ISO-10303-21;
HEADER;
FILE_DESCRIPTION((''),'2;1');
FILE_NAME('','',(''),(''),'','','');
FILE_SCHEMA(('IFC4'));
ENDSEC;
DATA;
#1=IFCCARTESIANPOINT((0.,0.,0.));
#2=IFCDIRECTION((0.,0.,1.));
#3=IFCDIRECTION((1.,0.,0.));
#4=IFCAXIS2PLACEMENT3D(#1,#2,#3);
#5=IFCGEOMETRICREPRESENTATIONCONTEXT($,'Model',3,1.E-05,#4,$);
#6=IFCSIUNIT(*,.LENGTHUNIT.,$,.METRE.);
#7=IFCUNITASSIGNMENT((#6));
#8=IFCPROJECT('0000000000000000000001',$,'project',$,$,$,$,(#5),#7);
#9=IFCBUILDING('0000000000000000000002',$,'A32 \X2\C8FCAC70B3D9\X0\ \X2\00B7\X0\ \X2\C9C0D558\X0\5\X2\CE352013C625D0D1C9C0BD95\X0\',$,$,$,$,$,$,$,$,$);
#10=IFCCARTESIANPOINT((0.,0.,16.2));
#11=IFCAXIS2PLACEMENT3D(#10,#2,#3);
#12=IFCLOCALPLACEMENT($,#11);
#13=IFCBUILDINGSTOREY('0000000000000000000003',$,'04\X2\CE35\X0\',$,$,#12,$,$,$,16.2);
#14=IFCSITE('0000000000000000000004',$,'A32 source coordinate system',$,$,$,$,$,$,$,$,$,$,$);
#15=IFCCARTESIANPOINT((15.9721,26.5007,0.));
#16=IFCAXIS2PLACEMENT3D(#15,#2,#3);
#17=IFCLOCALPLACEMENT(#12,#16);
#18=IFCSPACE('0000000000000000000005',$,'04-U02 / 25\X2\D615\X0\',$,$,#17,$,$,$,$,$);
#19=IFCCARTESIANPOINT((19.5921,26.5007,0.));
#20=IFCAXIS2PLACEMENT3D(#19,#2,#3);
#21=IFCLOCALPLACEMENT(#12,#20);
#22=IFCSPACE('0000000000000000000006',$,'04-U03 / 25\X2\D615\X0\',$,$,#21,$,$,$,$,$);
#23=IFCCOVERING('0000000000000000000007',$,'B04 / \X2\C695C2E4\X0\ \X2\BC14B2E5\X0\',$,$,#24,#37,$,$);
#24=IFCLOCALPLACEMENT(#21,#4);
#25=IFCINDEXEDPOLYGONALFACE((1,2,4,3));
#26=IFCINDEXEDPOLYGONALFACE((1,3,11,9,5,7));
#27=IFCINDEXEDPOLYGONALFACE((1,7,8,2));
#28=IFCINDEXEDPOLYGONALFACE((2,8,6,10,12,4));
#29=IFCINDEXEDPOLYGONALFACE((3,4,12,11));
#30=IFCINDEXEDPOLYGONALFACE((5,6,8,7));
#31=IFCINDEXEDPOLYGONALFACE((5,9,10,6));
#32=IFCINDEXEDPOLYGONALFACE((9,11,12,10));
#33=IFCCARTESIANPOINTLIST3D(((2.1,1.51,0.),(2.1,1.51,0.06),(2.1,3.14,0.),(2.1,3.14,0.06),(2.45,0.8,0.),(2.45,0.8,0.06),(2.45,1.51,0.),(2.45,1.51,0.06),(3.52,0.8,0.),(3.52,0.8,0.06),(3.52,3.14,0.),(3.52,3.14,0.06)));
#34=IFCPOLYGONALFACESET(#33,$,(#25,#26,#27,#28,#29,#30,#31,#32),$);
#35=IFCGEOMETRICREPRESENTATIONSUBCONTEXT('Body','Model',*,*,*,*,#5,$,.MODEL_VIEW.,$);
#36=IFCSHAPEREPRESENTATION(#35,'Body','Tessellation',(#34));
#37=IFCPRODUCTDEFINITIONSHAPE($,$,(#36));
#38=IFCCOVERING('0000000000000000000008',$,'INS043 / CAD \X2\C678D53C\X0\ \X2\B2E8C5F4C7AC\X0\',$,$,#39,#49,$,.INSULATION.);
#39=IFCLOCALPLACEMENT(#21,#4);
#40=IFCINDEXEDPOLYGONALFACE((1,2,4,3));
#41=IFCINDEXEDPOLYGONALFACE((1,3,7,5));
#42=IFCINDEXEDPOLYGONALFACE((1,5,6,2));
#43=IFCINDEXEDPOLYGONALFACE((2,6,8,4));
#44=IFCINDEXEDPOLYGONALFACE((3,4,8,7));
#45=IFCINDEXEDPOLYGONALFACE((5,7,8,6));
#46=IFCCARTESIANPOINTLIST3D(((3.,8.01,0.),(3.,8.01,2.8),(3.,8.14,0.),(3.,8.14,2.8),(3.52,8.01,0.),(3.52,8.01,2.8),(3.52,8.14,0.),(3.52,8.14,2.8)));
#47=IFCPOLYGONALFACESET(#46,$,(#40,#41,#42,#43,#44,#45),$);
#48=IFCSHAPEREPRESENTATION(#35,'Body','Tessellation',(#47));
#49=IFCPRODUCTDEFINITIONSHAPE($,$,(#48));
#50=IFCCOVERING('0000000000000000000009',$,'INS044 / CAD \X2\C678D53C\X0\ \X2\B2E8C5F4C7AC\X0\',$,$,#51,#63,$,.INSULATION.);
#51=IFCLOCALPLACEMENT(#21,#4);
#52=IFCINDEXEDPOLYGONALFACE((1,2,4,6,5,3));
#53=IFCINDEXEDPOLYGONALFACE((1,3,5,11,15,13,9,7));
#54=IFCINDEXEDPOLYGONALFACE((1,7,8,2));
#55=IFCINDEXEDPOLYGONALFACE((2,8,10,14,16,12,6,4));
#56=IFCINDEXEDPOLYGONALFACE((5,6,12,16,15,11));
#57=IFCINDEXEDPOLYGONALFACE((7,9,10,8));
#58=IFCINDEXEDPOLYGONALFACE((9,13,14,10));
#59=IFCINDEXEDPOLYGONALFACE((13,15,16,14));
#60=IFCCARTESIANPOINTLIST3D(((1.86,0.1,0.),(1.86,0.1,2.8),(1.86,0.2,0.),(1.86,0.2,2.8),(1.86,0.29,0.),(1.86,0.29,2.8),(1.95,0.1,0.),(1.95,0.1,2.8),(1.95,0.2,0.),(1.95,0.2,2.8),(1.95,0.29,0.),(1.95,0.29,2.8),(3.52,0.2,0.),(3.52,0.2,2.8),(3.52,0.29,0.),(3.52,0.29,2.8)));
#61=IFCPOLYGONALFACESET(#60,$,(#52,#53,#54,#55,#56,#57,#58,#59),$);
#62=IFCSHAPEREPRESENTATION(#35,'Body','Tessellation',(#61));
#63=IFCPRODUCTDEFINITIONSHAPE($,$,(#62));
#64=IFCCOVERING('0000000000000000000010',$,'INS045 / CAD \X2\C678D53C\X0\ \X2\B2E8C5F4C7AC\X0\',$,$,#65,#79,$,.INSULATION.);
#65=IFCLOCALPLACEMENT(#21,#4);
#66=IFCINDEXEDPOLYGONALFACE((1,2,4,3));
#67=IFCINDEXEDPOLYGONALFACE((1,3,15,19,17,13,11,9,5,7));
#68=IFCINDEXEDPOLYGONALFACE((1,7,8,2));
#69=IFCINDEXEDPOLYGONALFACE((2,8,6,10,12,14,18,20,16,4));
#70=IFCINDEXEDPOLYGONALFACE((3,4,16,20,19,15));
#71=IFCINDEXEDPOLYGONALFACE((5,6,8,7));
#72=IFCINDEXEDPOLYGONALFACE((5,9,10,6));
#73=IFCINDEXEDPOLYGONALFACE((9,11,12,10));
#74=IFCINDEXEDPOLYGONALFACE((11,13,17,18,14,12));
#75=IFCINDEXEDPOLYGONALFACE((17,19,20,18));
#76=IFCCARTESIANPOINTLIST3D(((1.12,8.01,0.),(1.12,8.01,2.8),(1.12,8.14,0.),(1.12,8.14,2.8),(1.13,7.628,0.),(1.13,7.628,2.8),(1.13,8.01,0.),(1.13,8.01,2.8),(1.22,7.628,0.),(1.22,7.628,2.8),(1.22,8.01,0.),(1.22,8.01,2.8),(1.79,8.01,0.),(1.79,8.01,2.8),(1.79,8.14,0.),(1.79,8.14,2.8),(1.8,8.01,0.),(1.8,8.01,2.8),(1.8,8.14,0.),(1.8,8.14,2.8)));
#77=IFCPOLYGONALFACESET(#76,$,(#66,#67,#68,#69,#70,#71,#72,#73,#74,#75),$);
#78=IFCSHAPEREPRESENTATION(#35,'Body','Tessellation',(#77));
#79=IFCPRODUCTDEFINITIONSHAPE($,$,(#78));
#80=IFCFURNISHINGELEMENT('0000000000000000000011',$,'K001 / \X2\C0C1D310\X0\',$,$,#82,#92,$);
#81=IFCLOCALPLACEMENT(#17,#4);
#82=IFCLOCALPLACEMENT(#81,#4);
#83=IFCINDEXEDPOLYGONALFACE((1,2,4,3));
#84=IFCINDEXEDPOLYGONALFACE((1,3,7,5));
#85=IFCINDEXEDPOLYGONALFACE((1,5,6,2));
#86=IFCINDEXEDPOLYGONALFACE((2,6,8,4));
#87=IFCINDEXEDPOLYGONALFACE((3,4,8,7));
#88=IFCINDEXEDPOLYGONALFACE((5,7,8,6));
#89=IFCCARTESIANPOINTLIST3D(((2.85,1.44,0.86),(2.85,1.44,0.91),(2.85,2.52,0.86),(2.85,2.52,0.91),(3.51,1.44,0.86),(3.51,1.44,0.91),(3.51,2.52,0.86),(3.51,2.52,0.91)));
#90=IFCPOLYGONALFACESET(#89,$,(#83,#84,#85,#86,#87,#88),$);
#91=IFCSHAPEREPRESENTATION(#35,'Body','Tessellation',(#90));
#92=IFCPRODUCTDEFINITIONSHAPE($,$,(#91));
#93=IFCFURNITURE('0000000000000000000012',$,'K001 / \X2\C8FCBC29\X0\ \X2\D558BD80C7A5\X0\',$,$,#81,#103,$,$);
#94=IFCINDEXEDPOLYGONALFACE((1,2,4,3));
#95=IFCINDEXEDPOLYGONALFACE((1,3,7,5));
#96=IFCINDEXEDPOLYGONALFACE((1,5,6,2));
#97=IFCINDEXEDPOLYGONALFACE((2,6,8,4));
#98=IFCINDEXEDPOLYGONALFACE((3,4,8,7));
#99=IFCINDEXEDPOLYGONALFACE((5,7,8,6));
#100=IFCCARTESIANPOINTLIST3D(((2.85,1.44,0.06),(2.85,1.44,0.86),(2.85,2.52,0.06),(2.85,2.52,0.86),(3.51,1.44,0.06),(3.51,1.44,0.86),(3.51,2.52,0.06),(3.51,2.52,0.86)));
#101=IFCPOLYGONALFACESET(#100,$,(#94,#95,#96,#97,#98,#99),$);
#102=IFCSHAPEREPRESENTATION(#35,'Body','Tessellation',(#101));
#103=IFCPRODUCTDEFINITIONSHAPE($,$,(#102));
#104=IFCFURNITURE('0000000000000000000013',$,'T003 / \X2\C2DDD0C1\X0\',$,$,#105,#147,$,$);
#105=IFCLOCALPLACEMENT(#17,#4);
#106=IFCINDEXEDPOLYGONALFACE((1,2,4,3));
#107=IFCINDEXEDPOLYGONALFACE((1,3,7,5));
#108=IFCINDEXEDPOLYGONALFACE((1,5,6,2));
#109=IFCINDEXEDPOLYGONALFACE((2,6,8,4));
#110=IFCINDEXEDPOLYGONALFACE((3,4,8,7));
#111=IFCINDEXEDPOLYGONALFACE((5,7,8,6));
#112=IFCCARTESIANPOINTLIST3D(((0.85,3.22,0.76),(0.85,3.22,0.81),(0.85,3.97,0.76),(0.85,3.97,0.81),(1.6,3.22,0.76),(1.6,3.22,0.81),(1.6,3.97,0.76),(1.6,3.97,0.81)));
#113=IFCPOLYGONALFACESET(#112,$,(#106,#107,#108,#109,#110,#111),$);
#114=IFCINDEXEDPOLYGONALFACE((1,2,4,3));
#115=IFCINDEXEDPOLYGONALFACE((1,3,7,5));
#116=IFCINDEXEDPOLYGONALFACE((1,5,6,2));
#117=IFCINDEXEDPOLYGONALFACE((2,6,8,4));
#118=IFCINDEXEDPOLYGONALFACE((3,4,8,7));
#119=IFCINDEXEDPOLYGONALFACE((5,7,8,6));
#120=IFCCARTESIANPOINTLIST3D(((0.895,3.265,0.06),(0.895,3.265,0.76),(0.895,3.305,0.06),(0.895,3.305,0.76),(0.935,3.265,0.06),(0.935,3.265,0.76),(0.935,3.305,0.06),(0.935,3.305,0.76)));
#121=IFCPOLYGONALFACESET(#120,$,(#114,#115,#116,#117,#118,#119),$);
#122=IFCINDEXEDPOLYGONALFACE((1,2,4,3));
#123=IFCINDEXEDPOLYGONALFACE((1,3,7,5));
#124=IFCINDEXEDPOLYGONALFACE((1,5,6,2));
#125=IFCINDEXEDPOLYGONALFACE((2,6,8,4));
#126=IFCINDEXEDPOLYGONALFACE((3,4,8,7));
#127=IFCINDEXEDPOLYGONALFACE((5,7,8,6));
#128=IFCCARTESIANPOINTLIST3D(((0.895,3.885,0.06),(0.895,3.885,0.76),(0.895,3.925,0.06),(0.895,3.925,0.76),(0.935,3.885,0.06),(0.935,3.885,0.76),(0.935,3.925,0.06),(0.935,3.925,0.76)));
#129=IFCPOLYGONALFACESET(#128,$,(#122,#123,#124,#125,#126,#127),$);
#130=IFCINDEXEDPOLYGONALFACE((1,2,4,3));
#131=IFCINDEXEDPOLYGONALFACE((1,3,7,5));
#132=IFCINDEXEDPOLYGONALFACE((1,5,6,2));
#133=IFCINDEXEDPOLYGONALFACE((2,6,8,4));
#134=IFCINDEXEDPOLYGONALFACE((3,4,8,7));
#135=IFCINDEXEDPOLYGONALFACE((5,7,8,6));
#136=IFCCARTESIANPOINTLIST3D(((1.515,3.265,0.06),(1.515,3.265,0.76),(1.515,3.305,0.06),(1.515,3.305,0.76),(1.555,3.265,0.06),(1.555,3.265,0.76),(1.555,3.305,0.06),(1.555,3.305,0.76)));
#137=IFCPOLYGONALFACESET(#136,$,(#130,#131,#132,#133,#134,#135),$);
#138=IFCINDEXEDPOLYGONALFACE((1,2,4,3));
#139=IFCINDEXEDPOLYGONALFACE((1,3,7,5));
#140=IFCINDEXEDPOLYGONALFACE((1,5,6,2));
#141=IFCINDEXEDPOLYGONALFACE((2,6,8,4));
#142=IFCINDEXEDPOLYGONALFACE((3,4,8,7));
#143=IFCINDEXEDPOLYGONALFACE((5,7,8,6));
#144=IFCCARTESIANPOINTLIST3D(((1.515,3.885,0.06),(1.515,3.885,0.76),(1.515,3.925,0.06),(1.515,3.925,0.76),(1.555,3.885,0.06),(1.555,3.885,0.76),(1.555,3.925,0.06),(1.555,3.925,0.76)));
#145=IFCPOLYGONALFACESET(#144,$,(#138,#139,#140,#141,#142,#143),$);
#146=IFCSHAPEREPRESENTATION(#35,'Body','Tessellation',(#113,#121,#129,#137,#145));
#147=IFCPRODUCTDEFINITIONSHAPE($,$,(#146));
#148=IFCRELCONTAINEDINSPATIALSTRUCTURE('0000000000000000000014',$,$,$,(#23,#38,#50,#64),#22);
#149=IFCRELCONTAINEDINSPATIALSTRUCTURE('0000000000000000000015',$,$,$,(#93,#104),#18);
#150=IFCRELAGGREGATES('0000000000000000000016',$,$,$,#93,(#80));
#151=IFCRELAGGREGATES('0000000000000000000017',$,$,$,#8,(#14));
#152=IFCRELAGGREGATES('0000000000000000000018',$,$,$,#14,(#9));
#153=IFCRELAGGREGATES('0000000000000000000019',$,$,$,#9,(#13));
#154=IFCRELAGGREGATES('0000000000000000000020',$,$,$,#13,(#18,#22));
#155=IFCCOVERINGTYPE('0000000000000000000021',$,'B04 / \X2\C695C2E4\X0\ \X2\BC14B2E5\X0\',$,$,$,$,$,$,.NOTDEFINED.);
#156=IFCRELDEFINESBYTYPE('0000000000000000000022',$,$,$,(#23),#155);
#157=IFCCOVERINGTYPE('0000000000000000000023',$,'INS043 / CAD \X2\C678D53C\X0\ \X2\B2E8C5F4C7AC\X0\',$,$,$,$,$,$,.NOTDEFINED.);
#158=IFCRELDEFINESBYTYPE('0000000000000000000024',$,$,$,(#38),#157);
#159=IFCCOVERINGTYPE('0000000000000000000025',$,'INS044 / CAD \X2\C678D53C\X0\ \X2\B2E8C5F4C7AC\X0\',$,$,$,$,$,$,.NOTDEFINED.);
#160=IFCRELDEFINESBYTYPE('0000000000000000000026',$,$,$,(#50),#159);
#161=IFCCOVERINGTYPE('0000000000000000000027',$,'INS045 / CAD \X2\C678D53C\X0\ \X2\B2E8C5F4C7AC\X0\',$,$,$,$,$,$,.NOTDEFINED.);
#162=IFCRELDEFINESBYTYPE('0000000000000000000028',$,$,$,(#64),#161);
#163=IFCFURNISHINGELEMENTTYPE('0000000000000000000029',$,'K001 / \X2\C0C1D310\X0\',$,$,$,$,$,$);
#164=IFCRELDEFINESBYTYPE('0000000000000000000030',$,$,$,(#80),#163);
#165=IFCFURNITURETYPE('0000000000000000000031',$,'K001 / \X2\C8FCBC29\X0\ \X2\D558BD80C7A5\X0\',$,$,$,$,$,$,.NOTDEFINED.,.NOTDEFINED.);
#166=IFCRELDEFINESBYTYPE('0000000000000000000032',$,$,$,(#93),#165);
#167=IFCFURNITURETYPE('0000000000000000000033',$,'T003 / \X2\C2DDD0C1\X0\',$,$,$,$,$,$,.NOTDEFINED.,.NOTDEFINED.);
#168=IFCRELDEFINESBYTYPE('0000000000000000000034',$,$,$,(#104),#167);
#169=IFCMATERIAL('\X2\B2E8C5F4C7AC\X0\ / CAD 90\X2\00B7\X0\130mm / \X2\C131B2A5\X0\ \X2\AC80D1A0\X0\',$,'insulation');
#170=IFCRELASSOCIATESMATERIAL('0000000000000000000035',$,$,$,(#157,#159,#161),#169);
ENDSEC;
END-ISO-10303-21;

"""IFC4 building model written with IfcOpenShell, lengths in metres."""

from ifc_helpers import new_model, si_unit, frame, origin, origin_with_axes, place, context, subcontext, project, spatial, polyline, outline, extrude, source, transform, mapped, material, type_object, type_shapes, element, aggregate, save


model = new_model("IFC4")

# Units and contexts
model_context = context("Model", 3, precision=1e-05, world=origin_with_axes())
body_context = subcontext(model_context, "Body", "Model", "MODEL_VIEW")
ifc_project = project(units=[si_unit("LENGTHUNIT", "METRE")], contexts=[model_context])

# Site, building, storey, space
site = spatial("IfcSite", under=ifc_project, Name="A32 source coordinate system")
building = spatial("IfcBuilding", under=site, Name="A32 주거동 · 지하5층–옥탑지붕")
storey_placement = place(None, frame((0.0, 0.0, 16.2), z_axis=(0.0, 0.0, 1.0), x_axis=(1.0, 0.0, 0.0)))
storey = spatial("IfcBuildingStorey", under=building, at=storey_placement, Name="04층", Elevation=16.2)
space_1_placement = place(storey_placement, frame((15.9721, 26.5007, 0.0), z_axis=(0.0, 0.0, 1.0), x_axis=(1.0, 0.0, 0.0)))
space_1 = spatial("IfcSpace", under=storey, at=space_1_placement, Name="04-U02 / 25형")

# Shared definitions
space_2_placement = place(storey_placement, frame((19.5921, 26.5007, 0.0), z_axis=(0.0, 0.0, 1.0), x_axis=(1.0, 0.0, 0.0)))
space_2 = spatial("IfcSpace", under=storey, at=space_2_placement, Name="04-U03 / 25형")

# Coverings
covering_type_1 = type_object("IfcCoveringType", Name="B04 / 욕실 바닥", PredefinedType="NOTDEFINED")
shared_shape_1 = source(origin(), body_context, "Body", "SweptSolid", [
    extrude(outline(polyline([(2.1, 1.51), (2.1, 3.14), (3.52, 3.14), (3.52, 0.8), (2.45, 0.8), (2.45, 1.51), (2.1, 1.51)])), origin(), (0.0, 0.0, 1.0), 0.06),
])
type_shapes(covering_type_1, [shared_shape_1])
covering_1_placement = place(space_2_placement, origin_with_axes())
element("IfcCovering", 1, at=covering_1_placement, inside=space_2, type_object=covering_type_1, Name="B04 / 욕실 바닥", context=body_context, shape_type="MappedRepresentation", body=[
    mapped(shared_shape_1, transform((0.0, 0.0, 0.0), scale=1.0)),
])
ifc_material = material(Name="단열재 / CAD 90·130mm / 성능 검토", Category="insulation")
covering_type_2 = type_object("IfcCoveringType", Name="INS043 / CAD 외피 단열재", PredefinedType="NOTDEFINED", material=ifc_material)
shared_shape_2 = source(origin(), body_context, "Body", "SweptSolid", [
    extrude(outline(polyline([(3.52, 8.14), (3.52, 8.01), (3.0, 8.01), (3.0, 8.14), (3.52, 8.14)])), origin(), (0.0, 0.0, 1.0), 2.8),
])
type_shapes(covering_type_2, [shared_shape_2])
covering_2_placement = place(space_2_placement, origin_with_axes())
element("IfcCovering", 2, at=covering_2_placement, inside=space_2, type_object=covering_type_2, Name="INS043 / CAD 외피 단열재", PredefinedType="INSULATION", context=body_context, shape_type="MappedRepresentation", body=[
    mapped(shared_shape_2, transform((0.0, 0.0, 0.0), scale=1.0)),
])
covering_type_3 = type_object("IfcCoveringType", Name="INS044 / CAD 외피 단열재", PredefinedType="NOTDEFINED", material=ifc_material)
shared_shape_3 = source(origin(), body_context, "Body", "SweptSolid", [
    extrude(outline(polyline([(1.86, 0.2), (1.86, 0.29), (1.95, 0.29), (3.52, 0.29), (3.52, 0.2), (1.95, 0.2), (1.95, 0.1), (1.86, 0.1), (1.86, 0.2)])), origin(), (0.0, 0.0, 1.0), 2.8),
])
type_shapes(covering_type_3, [shared_shape_3])
covering_3_placement = place(space_2_placement, origin_with_axes())
element("IfcCovering", 3, at=covering_3_placement, inside=space_2, type_object=covering_type_3, Name="INS044 / CAD 외피 단열재", PredefinedType="INSULATION", context=body_context, shape_type="MappedRepresentation", body=[
    mapped(shared_shape_3, transform((0.0, 0.0, 0.0), scale=1.0)),
])
covering_type_4 = type_object("IfcCoveringType", Name="INS045 / CAD 외피 단열재", PredefinedType="NOTDEFINED", material=ifc_material)
shared_shape_4 = source(origin(), body_context, "Body", "SweptSolid", [
    extrude(outline(polyline([(1.22, 8.01), (1.22, 7.628), (1.13, 7.628), (1.13, 8.01), (1.12, 8.01), (1.12, 8.14), (1.79, 8.14), (1.8, 8.14), (1.8, 8.01), (1.79, 8.01), (1.22, 8.01)])), origin(), (0.0, 0.0, 1.0), 2.8),
])
type_shapes(covering_type_4, [shared_shape_4])
covering_4_placement = place(space_2_placement, origin_with_axes())
element("IfcCovering", 4, at=covering_4_placement, inside=space_2, type_object=covering_type_4, Name="INS045 / CAD 외피 단열재", PredefinedType="INSULATION", context=body_context, shape_type="MappedRepresentation", body=[
    mapped(shared_shape_4, transform((0.0, 0.0, 0.0), scale=1.0)),
])

# Furnishing element
furnishing_element_type_1 = type_object("IfcFurnishingElementType", Name="K001 / 상판")
shared_shape_5 = source(origin(), body_context, "Body", "SweptSolid", [
    extrude(outline(polyline([(2.85, 2.52), (3.51, 2.52), (3.51, 1.44), (2.85, 1.44), (2.85, 2.52)])), frame((0.0, 0.0, 0.86)), (0.0, 0.0, 1.0), 0.05),
])
type_shapes(furnishing_element_type_1, [shared_shape_5])
furniture_1_placement = place(space_1_placement, origin_with_axes())
furnishing_1_placement = place(furniture_1_placement, origin_with_axes())
furnishing_1 = element("IfcFurnishingElement", 5, at=furnishing_1_placement, type_object=furnishing_element_type_1, Name="K001 / 상판", context=body_context, shape_type="MappedRepresentation", body=[
    mapped(shared_shape_5, transform((0.0, 0.0, 0.0), scale=1.0)),
])

# Furniture
furniture_type_1 = type_object("IfcFurnitureType", Name="K001 / 주방 하부장", AssemblyPlace="NOTDEFINED", PredefinedType="NOTDEFINED")
shared_shape_6 = source(origin(), body_context, "Body", "SweptSolid", [
    extrude(outline(polyline([(2.85, 1.44), (2.85, 2.52), (3.51, 2.52), (3.51, 1.44), (2.85, 1.44)])), frame((0.0, 0.0, 0.06)), (0.0, 0.0, 1.0), 0.8),
])
type_shapes(furniture_type_1, [shared_shape_6])
furniture_1 = element("IfcFurniture", 6, at=furniture_1_placement, inside=space_1, type_object=furniture_type_1, Name="K001 / 주방 하부장", context=body_context, shape_type="MappedRepresentation", body=[
    mapped(shared_shape_6, transform((0.0, 0.0, 0.0), scale=1.0)),
])
aggregate(furniture_1, [furnishing_1])
furniture_type_2 = type_object("IfcFurnitureType", Name="T003 / 식탁", AssemblyPlace="NOTDEFINED", PredefinedType="NOTDEFINED")
shared_shape_7 = source(origin(), body_context, "Body", "SweptSolid", [
    extrude(outline(polyline([(1.6, 3.97), (1.6, 3.22), (0.85, 3.22), (0.85, 3.97), (1.6, 3.97)])), frame((0.0, 0.0, 0.76)), (0.0, 0.0, 1.0), 0.05),
    extrude(outline(polyline([(0.895, 3.265), (0.895, 3.305), (0.935, 3.305), (0.935, 3.265), (0.895, 3.265)])), frame((0.0, 0.0, 0.06)), (0.0, 0.0, 1.0), 0.7),
    extrude(outline(polyline([(0.895, 3.885), (0.895, 3.925), (0.935, 3.925), (0.935, 3.885), (0.895, 3.885)])), frame((0.0, 0.0, 0.06)), (0.0, 0.0, 1.0), 0.7),
    extrude(outline(polyline([(1.515, 3.265), (1.515, 3.305), (1.555, 3.305), (1.555, 3.265), (1.515, 3.265)])), frame((0.0, 0.0, 0.06)), (0.0, 0.0, 1.0), 0.7),
    extrude(outline(polyline([(1.515, 3.885), (1.515, 3.925), (1.555, 3.925), (1.555, 3.885), (1.515, 3.885)])), frame((0.0, 0.0, 0.06)), (0.0, 0.0, 1.0), 0.7),
])
type_shapes(furniture_type_2, [shared_shape_7])
furniture_2_placement = place(space_1_placement, origin_with_axes())
element("IfcFurniture", 7, at=furniture_2_placement, inside=space_1, type_object=furniture_type_2, Name="T003 / 식탁", context=body_context, shape_type="MappedRepresentation", body=[
    mapped(shared_shape_7, transform((0.0, 0.0, 0.0), scale=1.0)),
])

save(model, "model.ifc")
